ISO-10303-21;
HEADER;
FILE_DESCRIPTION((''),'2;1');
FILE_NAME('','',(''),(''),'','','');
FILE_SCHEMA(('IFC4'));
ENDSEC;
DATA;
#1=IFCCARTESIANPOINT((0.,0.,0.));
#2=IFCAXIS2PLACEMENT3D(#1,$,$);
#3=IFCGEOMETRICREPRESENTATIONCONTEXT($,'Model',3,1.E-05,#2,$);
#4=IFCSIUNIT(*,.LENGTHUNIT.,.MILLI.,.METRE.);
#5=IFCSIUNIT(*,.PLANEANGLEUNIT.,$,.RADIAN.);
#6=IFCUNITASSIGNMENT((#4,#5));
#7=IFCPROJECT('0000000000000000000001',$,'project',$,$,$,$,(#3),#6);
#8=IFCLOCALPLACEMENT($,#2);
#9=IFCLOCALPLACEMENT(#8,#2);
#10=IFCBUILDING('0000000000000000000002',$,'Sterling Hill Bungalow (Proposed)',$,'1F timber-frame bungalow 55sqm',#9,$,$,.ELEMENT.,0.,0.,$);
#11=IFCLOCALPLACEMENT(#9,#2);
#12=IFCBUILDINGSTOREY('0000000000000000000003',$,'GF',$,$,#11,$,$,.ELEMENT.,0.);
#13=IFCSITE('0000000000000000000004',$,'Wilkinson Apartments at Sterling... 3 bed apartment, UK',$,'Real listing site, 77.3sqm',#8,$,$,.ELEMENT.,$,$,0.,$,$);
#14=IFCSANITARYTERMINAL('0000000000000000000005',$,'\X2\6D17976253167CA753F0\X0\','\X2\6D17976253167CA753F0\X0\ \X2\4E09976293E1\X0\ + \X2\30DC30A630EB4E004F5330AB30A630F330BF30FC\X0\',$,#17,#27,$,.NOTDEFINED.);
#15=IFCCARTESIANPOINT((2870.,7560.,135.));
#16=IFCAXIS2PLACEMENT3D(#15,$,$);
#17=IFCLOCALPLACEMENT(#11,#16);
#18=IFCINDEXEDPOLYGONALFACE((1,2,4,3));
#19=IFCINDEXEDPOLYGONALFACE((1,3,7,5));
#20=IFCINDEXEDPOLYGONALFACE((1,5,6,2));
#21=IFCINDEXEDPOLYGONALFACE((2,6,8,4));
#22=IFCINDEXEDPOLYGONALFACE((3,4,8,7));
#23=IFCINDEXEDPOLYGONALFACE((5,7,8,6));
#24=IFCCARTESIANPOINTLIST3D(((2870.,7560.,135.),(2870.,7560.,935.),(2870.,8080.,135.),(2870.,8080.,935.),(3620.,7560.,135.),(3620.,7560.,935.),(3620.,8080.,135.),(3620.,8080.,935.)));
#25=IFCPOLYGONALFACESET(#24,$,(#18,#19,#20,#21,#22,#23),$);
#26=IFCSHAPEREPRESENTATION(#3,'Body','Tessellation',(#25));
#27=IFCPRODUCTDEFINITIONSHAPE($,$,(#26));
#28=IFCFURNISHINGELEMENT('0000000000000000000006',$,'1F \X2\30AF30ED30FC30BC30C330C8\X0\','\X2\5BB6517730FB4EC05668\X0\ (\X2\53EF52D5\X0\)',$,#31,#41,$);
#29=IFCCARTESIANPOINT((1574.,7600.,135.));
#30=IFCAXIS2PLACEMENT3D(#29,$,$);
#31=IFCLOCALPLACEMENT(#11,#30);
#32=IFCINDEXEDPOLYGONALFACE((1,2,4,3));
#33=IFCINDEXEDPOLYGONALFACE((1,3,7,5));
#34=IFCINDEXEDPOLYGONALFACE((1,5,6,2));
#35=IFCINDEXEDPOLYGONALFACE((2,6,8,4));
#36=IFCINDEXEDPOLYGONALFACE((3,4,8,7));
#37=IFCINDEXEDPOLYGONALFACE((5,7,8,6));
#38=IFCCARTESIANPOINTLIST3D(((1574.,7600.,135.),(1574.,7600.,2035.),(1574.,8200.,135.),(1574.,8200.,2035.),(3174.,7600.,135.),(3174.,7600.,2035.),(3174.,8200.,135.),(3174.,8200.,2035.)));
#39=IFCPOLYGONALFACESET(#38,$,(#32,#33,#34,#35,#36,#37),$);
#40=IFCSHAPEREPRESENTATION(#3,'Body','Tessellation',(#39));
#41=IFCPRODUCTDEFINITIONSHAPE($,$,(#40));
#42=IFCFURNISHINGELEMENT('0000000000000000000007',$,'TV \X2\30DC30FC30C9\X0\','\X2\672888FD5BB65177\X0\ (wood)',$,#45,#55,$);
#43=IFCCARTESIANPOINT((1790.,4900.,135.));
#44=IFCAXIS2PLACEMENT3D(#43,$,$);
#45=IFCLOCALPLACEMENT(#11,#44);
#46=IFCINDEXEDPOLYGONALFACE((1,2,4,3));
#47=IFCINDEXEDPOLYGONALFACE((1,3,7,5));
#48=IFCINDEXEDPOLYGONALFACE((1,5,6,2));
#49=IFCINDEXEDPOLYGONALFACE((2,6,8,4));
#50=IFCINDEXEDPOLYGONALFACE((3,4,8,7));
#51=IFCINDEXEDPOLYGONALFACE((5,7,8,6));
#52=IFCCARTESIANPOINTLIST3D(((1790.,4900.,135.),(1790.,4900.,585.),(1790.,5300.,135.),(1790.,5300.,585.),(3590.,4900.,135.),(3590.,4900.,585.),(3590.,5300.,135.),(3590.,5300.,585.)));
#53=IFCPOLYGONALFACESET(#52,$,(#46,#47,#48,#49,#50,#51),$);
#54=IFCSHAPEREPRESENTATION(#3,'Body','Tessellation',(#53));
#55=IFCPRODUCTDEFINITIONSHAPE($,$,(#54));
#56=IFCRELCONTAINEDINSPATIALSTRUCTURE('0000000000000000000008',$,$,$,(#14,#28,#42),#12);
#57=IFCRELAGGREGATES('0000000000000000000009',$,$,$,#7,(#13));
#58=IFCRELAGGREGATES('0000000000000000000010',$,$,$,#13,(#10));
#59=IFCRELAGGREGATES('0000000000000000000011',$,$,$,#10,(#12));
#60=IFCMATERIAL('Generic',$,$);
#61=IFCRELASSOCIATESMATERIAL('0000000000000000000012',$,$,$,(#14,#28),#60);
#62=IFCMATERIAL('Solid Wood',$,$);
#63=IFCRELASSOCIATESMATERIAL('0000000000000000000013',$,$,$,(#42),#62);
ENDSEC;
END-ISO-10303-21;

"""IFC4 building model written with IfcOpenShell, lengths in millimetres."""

from ifc_helpers import new_model, si_unit, frame, frame_2d, origin, place, context, project, spatial, rectangle, extrude, material, element, save


model = new_model("IFC4")

# Units and contexts
model_context = context("Model", 3, precision=1e-05, world=origin())
ifc_project = project(units=[si_unit("LENGTHUNIT", "METRE", prefix="MILLI"), si_unit("PLANEANGLEUNIT", "RADIAN")], contexts=[model_context])

# Site, building, storey
site_placement = place(None, origin())
site = spatial("IfcSite", under=ifc_project, at=site_placement, Name="Wilkinson Apartments at Sterling... 3 bed apartment, UK", ObjectType="Real listing site, 77.3sqm", CompositionType="ELEMENT", RefElevation=0.0)
building_placement = place(site_placement, origin())
building = spatial("IfcBuilding", under=site, at=building_placement, Name="Sterling Hill Bungalow (Proposed)", ObjectType="1F timber-frame bungalow 55sqm", CompositionType="ELEMENT", ElevationOfRefHeight=0.0, ElevationOfTerrain=0.0)
storey_placement = place(building_placement, origin())
storey = spatial("IfcBuildingStorey", under=building, at=storey_placement, Name="GF", CompositionType="ELEMENT", Elevation=0.0)

# Shared definitions
ifc_material_1 = material(Name="Solid Wood")

# Shared definitions
ifc_material_2 = material(Name="Generic")

# Sanitary terminal
sanitary_terminal_1_placement = place(storey_placement, frame((2870.0, 7560.0, 135.0)))
element("IfcSanitaryTerminal", 1, at=sanitary_terminal_1_placement, inside=storey, material=ifc_material_2, Name="洗面化粧台", Description="洗面化粧台 三面鏡 + ボウル一体カウンター", PredefinedType="NOTDEFINED", context=model_context, shape_type="SweptSolid", body=[
    extrude(rectangle(XDim=750.0, YDim=520.0, at=frame_2d((375.0, 260.0))), frame((2870.0, 7560.0, 135.0)), (0.0, 0.0, 1.0), 800.0),
])

# Furnishing elements
furnishing_1_placement = place(storey_placement, frame((1574.0, 7600.0, 135.0)))
element("IfcFurnishingElement", 2, at=furnishing_1_placement, inside=storey, material=ifc_material_2, Name="1F クローゼット", Description="家具・什器 (可動)", context=model_context, shape_type="SweptSolid", body=[
    extrude(rectangle(XDim=1600.0, YDim=600.0, at=frame_2d((800.0, 300.0))), frame((1574.0, 7600.0, 135.0)), (0.0, 0.0, 1.0), 1900.0),
])
furnishing_2_placement = place(storey_placement, frame((1790.0, 4900.0, 135.0)))
element("IfcFurnishingElement", 3, at=furnishing_2_placement, inside=storey, material=ifc_material_1, Name="TV ボード", Description="木製家具 (wood)", context=model_context, shape_type="SweptSolid", body=[
    extrude(rectangle(XDim=1800.0, YDim=400.0, at=frame_2d((900.0, 200.0))), frame((1790.0, 4900.0, 135.0)), (0.0, 0.0, 1.0), 450.0),
])

save(model, "model.ifc")
